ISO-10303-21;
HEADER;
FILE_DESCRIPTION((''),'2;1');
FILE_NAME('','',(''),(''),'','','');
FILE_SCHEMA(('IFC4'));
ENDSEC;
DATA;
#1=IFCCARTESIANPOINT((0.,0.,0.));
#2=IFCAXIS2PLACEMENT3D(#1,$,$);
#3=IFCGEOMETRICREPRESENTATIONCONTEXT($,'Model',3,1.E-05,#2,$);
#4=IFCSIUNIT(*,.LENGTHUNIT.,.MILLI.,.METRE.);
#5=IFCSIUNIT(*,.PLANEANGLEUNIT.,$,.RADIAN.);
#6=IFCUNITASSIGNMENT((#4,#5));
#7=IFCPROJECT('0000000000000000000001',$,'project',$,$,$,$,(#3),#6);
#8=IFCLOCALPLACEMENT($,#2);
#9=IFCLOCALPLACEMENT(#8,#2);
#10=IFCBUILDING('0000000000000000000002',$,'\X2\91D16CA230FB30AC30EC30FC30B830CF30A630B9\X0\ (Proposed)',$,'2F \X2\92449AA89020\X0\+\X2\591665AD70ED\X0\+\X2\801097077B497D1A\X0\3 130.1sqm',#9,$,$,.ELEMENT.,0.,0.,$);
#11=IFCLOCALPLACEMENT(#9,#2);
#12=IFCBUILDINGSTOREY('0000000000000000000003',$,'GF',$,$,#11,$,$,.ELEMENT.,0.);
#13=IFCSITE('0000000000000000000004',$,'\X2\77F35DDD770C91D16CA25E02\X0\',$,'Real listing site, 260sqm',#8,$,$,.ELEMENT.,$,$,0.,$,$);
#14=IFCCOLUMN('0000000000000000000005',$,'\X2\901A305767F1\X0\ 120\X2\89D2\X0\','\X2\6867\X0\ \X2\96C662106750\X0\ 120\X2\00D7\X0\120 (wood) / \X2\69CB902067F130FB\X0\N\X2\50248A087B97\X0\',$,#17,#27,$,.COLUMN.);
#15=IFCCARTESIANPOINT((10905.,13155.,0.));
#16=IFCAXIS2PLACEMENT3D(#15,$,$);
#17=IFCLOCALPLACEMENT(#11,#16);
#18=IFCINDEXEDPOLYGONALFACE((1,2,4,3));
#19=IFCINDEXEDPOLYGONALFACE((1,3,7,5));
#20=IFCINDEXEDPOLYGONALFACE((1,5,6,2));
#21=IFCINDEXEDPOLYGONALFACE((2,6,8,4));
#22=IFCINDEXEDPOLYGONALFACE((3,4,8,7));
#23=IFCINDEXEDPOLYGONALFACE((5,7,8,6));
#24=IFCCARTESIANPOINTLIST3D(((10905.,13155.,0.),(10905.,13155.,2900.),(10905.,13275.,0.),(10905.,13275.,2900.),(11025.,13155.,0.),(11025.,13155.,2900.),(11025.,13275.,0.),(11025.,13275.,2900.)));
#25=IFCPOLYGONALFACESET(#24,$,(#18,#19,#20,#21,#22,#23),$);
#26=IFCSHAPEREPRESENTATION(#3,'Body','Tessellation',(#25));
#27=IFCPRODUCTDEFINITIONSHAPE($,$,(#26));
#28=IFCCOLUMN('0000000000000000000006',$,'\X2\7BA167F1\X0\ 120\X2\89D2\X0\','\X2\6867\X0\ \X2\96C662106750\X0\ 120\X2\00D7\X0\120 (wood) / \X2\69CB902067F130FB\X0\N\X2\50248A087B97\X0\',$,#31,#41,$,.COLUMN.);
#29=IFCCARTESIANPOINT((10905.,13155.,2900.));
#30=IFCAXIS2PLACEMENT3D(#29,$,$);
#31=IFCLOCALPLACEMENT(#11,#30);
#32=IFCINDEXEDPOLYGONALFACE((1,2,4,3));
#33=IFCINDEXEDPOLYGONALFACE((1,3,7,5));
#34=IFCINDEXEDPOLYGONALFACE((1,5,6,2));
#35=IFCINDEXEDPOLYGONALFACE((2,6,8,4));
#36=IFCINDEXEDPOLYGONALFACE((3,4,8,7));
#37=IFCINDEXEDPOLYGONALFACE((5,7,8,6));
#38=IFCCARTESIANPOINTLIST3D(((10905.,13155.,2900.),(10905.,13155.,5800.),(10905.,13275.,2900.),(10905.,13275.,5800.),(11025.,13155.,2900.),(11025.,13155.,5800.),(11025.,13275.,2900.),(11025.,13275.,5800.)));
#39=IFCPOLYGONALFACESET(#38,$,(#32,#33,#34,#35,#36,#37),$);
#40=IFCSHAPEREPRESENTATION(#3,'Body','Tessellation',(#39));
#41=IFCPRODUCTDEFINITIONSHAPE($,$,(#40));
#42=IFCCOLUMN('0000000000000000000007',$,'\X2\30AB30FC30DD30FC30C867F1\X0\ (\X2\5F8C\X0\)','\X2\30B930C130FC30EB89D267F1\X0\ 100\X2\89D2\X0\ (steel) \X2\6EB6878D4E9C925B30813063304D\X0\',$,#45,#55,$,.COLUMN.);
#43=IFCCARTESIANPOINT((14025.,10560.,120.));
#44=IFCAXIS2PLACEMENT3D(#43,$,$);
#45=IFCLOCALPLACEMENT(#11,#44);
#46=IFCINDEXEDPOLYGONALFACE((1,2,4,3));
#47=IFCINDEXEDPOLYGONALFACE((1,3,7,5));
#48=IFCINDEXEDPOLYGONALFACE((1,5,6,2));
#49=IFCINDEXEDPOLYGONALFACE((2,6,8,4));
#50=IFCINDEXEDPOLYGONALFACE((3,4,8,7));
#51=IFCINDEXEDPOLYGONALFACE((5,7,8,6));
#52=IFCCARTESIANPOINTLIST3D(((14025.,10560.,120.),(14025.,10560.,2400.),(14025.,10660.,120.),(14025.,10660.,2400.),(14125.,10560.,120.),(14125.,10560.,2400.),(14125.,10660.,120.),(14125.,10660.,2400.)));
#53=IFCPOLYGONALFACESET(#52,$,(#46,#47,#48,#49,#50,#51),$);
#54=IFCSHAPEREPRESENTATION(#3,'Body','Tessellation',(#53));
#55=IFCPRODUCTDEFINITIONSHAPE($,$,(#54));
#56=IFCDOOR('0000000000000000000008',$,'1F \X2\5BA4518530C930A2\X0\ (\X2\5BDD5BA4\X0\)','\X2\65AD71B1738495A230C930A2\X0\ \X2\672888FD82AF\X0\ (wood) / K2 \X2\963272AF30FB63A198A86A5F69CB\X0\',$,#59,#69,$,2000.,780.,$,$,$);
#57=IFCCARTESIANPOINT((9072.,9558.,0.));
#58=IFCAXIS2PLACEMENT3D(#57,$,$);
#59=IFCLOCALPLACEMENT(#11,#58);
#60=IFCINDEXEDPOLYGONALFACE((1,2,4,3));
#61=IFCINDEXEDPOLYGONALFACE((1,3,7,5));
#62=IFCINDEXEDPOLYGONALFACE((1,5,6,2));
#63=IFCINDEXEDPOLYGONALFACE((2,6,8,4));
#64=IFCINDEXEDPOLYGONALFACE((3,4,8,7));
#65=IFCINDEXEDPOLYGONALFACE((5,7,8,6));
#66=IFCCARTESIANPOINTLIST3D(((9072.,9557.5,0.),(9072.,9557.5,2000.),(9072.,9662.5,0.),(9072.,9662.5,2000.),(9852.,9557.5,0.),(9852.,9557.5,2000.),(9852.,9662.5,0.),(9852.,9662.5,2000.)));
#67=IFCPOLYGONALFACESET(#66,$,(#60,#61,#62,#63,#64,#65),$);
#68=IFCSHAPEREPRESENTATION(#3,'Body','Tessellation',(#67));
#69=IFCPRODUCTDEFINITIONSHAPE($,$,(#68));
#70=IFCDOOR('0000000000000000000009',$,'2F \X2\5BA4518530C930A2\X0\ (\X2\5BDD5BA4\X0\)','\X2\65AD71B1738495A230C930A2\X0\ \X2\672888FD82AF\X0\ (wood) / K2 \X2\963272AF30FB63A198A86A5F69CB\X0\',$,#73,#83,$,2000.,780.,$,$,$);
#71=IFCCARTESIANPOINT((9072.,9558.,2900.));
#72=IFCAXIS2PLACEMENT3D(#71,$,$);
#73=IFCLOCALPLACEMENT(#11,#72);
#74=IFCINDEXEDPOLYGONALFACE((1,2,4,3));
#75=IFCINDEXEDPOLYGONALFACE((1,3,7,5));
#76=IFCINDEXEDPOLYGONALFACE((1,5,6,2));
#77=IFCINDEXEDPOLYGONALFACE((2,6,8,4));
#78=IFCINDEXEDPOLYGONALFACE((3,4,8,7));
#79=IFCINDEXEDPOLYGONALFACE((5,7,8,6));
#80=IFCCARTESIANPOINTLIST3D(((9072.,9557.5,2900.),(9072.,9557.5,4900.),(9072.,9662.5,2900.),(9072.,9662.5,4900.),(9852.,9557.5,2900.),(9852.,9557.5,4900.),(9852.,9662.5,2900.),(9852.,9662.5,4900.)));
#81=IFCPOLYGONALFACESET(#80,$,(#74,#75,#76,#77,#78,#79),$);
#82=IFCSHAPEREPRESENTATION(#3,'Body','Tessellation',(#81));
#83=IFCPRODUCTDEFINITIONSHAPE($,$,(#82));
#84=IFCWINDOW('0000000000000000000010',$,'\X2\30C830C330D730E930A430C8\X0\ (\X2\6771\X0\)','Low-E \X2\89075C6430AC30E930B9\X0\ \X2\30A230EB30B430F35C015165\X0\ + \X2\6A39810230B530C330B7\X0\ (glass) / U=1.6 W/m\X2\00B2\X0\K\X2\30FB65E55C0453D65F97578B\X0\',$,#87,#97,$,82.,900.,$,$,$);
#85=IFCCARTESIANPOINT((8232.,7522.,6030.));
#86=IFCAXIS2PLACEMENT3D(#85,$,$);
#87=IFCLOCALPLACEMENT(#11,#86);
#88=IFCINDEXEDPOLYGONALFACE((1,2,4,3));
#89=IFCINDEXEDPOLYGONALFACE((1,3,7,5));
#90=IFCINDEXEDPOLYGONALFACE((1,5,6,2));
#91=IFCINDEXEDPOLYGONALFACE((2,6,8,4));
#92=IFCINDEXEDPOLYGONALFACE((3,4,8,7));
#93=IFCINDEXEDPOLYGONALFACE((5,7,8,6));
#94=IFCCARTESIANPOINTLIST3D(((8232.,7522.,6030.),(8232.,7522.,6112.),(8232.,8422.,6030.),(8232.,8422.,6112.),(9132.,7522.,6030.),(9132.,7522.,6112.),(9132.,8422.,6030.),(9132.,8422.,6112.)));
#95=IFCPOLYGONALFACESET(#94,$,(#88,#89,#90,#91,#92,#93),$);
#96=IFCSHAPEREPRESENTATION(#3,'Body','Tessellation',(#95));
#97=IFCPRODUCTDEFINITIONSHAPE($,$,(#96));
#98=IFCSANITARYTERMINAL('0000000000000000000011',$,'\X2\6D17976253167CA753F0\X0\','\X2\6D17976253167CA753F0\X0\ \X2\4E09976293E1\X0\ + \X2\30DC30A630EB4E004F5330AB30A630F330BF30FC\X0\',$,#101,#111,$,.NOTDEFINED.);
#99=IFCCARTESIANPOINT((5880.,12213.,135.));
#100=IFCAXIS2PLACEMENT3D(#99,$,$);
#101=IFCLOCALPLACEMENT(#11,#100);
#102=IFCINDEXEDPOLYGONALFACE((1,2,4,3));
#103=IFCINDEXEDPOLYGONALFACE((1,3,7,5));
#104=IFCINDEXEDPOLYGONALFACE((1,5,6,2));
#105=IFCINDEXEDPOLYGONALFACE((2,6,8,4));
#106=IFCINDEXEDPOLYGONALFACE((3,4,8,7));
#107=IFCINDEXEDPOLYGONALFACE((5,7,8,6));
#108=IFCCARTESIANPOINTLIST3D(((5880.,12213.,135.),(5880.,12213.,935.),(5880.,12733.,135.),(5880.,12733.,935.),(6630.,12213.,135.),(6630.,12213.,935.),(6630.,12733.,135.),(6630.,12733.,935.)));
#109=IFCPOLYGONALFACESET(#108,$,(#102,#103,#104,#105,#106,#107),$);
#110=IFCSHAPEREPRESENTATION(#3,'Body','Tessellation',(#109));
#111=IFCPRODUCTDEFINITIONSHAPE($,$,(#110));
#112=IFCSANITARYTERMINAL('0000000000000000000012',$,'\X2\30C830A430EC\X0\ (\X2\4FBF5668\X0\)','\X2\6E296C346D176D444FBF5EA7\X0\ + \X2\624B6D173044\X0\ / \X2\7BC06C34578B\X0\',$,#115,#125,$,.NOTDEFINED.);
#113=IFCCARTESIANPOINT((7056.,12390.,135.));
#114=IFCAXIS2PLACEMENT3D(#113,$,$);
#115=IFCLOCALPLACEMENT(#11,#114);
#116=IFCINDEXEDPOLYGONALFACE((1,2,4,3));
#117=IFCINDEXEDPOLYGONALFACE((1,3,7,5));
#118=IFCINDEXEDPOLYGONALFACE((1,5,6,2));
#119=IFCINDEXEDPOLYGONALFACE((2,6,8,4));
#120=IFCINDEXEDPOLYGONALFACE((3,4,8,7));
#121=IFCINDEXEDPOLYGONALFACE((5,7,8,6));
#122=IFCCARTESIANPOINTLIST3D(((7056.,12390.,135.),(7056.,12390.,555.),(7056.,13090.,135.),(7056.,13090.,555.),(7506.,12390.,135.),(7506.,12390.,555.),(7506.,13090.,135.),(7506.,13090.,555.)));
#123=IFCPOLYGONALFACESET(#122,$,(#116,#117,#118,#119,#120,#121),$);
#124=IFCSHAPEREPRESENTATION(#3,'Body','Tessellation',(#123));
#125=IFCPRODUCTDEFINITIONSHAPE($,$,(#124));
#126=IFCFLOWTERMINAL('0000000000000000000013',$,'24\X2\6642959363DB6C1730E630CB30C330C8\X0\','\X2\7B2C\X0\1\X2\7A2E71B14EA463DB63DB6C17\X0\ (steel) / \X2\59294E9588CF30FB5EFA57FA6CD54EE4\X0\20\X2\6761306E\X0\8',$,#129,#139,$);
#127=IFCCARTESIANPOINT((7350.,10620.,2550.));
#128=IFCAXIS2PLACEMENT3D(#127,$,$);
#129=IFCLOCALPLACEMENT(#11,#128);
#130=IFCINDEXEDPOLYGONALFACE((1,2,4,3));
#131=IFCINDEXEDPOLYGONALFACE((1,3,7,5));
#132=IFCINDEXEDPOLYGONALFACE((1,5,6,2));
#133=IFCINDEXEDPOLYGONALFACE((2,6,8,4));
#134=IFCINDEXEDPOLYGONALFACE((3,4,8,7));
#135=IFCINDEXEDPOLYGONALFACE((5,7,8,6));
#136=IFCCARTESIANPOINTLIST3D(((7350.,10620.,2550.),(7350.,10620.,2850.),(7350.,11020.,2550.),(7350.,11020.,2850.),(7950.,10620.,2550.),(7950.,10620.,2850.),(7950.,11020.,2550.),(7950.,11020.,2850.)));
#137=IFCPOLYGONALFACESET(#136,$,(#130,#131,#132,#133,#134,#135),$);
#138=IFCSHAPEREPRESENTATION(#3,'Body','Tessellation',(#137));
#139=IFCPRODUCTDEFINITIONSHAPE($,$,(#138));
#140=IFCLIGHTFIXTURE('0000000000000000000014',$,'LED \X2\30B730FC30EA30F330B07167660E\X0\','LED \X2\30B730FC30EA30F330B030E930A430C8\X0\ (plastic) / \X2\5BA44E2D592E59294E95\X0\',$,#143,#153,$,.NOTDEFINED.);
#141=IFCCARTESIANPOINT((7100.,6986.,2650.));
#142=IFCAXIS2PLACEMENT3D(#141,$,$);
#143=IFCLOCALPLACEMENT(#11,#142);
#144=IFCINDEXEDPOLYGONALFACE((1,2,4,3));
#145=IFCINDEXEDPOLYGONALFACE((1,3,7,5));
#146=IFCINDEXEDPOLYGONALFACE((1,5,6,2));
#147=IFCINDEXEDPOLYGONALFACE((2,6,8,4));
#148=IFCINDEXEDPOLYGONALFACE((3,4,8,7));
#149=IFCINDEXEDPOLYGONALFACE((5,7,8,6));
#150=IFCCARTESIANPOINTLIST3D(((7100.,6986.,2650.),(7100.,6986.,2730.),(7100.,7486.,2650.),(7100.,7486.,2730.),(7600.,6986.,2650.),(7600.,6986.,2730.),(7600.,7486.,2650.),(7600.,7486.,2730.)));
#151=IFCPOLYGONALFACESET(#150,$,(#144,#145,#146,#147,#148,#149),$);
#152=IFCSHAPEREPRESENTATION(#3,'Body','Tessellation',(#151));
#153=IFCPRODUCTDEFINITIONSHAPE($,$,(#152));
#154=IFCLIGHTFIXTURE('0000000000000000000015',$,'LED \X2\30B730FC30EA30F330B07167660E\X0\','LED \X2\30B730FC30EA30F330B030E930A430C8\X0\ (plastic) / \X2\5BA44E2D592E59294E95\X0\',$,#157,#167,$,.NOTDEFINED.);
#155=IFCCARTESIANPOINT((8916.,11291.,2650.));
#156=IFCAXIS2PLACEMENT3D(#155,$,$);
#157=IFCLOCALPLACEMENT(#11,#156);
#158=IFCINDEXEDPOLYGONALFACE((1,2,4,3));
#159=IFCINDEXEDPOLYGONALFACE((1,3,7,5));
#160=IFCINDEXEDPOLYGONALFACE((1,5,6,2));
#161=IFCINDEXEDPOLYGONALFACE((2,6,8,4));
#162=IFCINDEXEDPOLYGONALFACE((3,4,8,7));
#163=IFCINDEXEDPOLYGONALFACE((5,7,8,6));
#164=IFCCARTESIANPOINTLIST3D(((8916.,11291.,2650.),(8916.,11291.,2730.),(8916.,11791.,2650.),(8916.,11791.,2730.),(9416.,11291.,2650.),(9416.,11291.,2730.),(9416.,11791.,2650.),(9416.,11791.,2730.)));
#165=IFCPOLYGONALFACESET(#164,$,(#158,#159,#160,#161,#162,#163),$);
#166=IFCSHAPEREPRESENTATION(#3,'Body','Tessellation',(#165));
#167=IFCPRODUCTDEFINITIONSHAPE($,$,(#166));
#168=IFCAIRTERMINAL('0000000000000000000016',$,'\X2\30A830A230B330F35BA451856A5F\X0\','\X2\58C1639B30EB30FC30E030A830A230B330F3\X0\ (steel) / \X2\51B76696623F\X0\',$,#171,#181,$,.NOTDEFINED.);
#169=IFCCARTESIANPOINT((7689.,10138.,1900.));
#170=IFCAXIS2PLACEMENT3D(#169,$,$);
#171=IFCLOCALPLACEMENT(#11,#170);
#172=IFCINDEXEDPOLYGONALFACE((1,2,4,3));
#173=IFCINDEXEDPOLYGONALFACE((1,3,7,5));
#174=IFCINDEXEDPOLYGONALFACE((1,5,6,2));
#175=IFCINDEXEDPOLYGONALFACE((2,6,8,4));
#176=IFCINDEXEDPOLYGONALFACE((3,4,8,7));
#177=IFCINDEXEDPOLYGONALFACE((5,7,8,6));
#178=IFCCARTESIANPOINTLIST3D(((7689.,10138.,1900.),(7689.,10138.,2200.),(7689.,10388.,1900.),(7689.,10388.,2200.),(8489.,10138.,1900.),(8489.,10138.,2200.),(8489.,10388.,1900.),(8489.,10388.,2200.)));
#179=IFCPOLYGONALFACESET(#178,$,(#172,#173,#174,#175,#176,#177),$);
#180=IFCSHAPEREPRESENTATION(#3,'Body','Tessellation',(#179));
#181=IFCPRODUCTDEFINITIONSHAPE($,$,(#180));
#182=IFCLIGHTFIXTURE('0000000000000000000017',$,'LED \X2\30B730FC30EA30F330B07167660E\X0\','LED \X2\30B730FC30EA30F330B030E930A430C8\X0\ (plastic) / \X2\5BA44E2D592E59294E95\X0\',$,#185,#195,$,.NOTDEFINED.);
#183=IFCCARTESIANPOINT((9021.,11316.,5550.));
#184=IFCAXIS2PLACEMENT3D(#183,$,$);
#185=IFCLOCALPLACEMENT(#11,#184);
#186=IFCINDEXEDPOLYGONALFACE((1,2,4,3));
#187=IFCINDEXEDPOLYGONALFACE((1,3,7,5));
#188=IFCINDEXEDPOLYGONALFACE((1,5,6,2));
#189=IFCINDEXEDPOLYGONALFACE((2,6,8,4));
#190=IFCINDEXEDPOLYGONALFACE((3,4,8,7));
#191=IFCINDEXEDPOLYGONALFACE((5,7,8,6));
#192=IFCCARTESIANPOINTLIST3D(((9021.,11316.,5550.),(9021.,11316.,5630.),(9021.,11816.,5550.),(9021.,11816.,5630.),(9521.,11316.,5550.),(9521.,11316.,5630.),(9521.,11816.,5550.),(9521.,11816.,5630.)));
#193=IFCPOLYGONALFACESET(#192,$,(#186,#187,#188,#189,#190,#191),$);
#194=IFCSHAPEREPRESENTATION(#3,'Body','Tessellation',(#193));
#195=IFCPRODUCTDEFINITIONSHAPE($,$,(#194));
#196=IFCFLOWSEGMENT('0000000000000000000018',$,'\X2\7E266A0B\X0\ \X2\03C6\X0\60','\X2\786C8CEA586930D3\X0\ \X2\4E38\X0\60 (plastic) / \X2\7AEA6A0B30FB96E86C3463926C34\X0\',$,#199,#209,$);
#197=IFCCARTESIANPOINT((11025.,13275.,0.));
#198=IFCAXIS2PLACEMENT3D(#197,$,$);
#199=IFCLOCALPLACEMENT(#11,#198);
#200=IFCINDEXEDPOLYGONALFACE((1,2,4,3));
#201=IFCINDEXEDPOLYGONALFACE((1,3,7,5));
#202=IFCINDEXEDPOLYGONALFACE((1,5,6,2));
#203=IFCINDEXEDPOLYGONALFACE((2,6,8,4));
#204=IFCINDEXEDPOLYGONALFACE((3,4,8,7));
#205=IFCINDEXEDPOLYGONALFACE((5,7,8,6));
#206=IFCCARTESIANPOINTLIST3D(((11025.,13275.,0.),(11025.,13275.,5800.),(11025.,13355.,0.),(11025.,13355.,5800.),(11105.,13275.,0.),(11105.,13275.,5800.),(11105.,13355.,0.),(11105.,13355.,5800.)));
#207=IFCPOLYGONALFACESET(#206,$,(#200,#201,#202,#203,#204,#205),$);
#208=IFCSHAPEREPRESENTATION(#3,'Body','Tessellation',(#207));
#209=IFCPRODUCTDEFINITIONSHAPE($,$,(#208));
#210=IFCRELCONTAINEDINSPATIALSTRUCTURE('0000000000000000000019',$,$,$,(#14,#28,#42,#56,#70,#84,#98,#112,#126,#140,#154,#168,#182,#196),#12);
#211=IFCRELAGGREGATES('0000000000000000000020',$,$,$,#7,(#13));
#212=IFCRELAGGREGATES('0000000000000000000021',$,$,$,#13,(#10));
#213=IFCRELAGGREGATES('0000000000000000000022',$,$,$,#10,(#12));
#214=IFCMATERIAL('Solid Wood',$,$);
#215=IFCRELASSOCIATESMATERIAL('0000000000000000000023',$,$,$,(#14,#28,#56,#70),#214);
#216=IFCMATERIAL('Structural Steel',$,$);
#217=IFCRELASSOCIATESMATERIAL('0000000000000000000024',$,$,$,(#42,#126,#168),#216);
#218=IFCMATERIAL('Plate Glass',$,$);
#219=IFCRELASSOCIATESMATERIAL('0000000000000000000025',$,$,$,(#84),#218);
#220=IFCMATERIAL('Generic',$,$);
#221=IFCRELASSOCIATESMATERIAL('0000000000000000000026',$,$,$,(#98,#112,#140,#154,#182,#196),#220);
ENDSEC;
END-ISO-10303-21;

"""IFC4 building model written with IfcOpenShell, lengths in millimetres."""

from ifc_helpers import new_model, si_unit, frame, frame_2d, origin, place, context, project, spatial, rectangle, extrude, material, element, save


model = new_model("IFC4")

# Units and contexts
model_context = context("Model", 3, precision=1e-05, world=origin())
ifc_project = project(units=[si_unit("LENGTHUNIT", "METRE", prefix="MILLI"), si_unit("PLANEANGLEUNIT", "RADIAN")], contexts=[model_context])

# Site, building, storey
site_placement = place(None, origin())
site = spatial("IfcSite", under=ifc_project, at=site_placement, Name="石川県金沢市", ObjectType="Real listing site, 260sqm", CompositionType="ELEMENT", RefElevation=0.0)
building_placement = place(site_placement, origin())
building = spatial("IfcBuilding", under=site, at=building_placement, Name="金沢・ガレージハウス (Proposed)", ObjectType="2F 鉄骨造+外断热+耐震等級3 130.1sqm", CompositionType="ELEMENT", ElevationOfRefHeight=0.0, ElevationOfTerrain=0.0)
storey_placement = place(building_placement, origin())
storey = spatial("IfcBuildingStorey", under=building, at=storey_placement, Name="GF", CompositionType="ELEMENT", Elevation=0.0)

# Columns
ifc_material_1 = material(Name="Solid Wood")
column_1_placement = place(storey_placement, frame((10905.0, 13155.0, 0.0)))
element("IfcColumn", 1, at=column_1_placement, inside=storey, material=ifc_material_1, Name="通し柱 120角", Description="桧 集成材 120×120 (wood) / 構造柱・N値計算", PredefinedType="COLUMN", context=model_context, shape_type="SweptSolid", body=[
    extrude(rectangle(XDim=120.0, YDim=120.0, at=frame_2d((60.0, 60.0))), frame((10905.0, 13155.0, 0.0)), (0.0, 0.0, 1.0), 2900.0),
])
column_2_placement = place(storey_placement, frame((10905.0, 13155.0, 2900.0)))
element("IfcColumn", 2, at=column_2_placement, inside=storey, material=ifc_material_1, Name="管柱 120角", Description="桧 集成材 120×120 (wood) / 構造柱・N値計算", PredefinedType="COLUMN", context=model_context, shape_type="SweptSolid", body=[
    extrude(rectangle(XDim=120.0, YDim=120.0, at=frame_2d((60.0, 60.0))), frame((10905.0, 13155.0, 2900.0)), (0.0, 0.0, 1.0), 2900.0),
])
ifc_material_2 = material(Name="Structural Steel")
column_3_placement = place(storey_placement, frame((14025.0, 10560.0, 120.0)))
element("IfcColumn", 3, at=column_3_placement, inside=storey, material=ifc_material_2, Name="カーポート柱 (後)", Description="スチール角柱 100角 (steel) 溶融亜鉛めっき", PredefinedType="COLUMN", context=model_context, shape_type="SweptSolid", body=[
    extrude(rectangle(XDim=100.0, YDim=100.0, at=frame_2d((50.0, 50.0))), frame((14025.0, 10560.0, 120.0)), (0.0, 0.0, 1.0), 2280.0),
])

# Door
door_1_placement = place(storey_placement, frame((9072.0, 9558.0, 0.0)))
element("IfcDoor", 4, at=door_1_placement, inside=storey, material=ifc_material_1, Name="1F 室内ドア (寝室)", Description="断熱玄関ドア 木製芯 (wood) / K2 防犯・採風機構", OverallHeight=2000.0, OverallWidth=780.0, context=model_context, shape_type="SweptSolid", body=[
    extrude(rectangle(XDim=780.0, YDim=105.0, at=frame_2d((390.0, 52.0))), frame((9072.0, 9558.0, 0.0)), (0.0, 0.0, 1.0), 2000.0),
])

# Door
door_2_placement = place(storey_placement, frame((9072.0, 9558.0, 2900.0)))
element("IfcDoor", 5, at=door_2_placement, inside=storey, material=ifc_material_1, Name="2F 室内ドア (寝室)", Description="断熱玄関ドア 木製芯 (wood) / K2 防犯・採風機構", OverallHeight=2000.0, OverallWidth=780.0, context=model_context, shape_type="SweptSolid", body=[
    extrude(rectangle(XDim=780.0, YDim=105.0, at=frame_2d((390.0, 52.0))), frame((9072.0, 9558.0, 2900.0)), (0.0, 0.0, 1.0), 2000.0),
])

# Window
ifc_material_3 = material(Name="Plate Glass")
window_placement = place(storey_placement, frame((8232.0, 7522.0, 6030.0)))
element("IfcWindow", 6, at=window_placement, inside=storey, material=ifc_material_3, Name="トップライト (東)", Description="Low-E 複層ガラス アルゴン封入 + 樹脂サッシ (glass) / U=1.6 W/m²K・日射取得型", OverallHeight=82.0, OverallWidth=900.0, context=model_context, shape_type="SweptSolid", body=[
    extrude(rectangle(XDim=900.0, YDim=900.0, at=frame_2d((450.0, 450.0))), frame((8232.0, 7522.0, 6030.0)), (0.0, 0.0, 1.0), 82.0),
])

# Sanitary terminals
ifc_material_4 = material(Name="Generic")
sanitary_terminal_1_placement = place(storey_placement, frame((5880.0, 12213.0, 135.0)))
element("IfcSanitaryTerminal", 7, at=sanitary_terminal_1_placement, inside=storey, material=ifc_material_4, Name="洗面化粧台", Description="洗面化粧台 三面鏡 + ボウル一体カウンター", PredefinedType="NOTDEFINED", context=model_context, shape_type="SweptSolid", body=[
    extrude(rectangle(XDim=750.0, YDim=520.0, at=frame_2d((375.0, 260.0))), frame((5880.0, 12213.0, 135.0)), (0.0, 0.0, 1.0), 800.0),
])
sanitary_terminal_2_placement = place(storey_placement, frame((7056.0, 12390.0, 135.0)))
element("IfcSanitaryTerminal", 8, at=sanitary_terminal_2_placement, inside=storey, material=ifc_material_4, Name="トイレ (便器)", Description="温水洗浄便座 + 手洗い / 節水型", PredefinedType="NOTDEFINED", context=model_context, shape_type="SweptSolid", body=[
    extrude(rectangle(XDim=450.0, YDim=700.0, at=frame_2d((225.0, 350.0))), frame((7056.0, 12390.0, 135.0)), (0.0, 0.0, 1.0), 420.0),
])

# Flow terminal
flow_terminal_placement = place(storey_placement, frame((7350.0, 10620.0, 2550.0)))
element("IfcFlowTerminal", 9, at=flow_terminal_placement, inside=storey, material=ifc_material_2, Name="24時間換気ユニット", Description="第1種熱交換換気 (steel) / 天井裏・建基法令20条の8", context=model_context, shape_type="SweptSolid", body=[
    extrude(rectangle(XDim=600.0, YDim=400.0, at=frame_2d((300.0, 200.0))), frame((7350.0, 10620.0, 2550.0)), (0.0, 0.0, 1.0), 300.0),
])

# Light fixtures
light_fixture_1_placement = place(storey_placement, frame((7100.0, 6986.0, 2650.0)))
element("IfcLightFixture", 10, at=light_fixture_1_placement, inside=storey, material=ifc_material_4, Name="LED シーリング照明", Description="LED シーリングライト (plastic) / 室中央天井", PredefinedType="NOTDEFINED", context=model_context, shape_type="SweptSolid", body=[
    extrude(rectangle(XDim=500.0, YDim=500.0, at=frame_2d((250.0, 250.0))), frame((7100.0, 6986.0, 2650.0)), (0.0, 0.0, 1.0), 80.0),
])
light_fixture_2_placement = place(storey_placement, frame((8916.0, 11291.0, 2650.0)))
element("IfcLightFixture", 11, at=light_fixture_2_placement, inside=storey, material=ifc_material_4, Name="LED シーリング照明", Description="LED シーリングライト (plastic) / 室中央天井", PredefinedType="NOTDEFINED", context=model_context, shape_type="SweptSolid", body=[
    extrude(rectangle(XDim=500.0, YDim=500.0, at=frame_2d((250.0, 250.0))), frame((8916.0, 11291.0, 2650.0)), (0.0, 0.0, 1.0), 80.0),
])

# Air terminal
air_terminal_placement = place(storey_placement, frame((7689.0, 10138.0, 1900.0)))
element("IfcAirTerminal", 12, at=air_terminal_placement, inside=storey, material=ifc_material_2, Name="エアコン室内機", Description="壁掛ルームエアコン (steel) / 冷暖房", PredefinedType="NOTDEFINED", context=model_context, shape_type="SweptSolid", body=[
    extrude(rectangle(XDim=800.0, YDim=250.0, at=frame_2d((400.0, 125.0))), frame((7689.0, 10138.0, 1900.0)), (0.0, 0.0, 1.0), 300.0),
])

# Light fixture
light_fixture_3_placement = place(storey_placement, frame((9021.0, 11316.0, 5550.0)))
element("IfcLightFixture", 13, at=light_fixture_3_placement, inside=storey, material=ifc_material_4, Name="LED シーリング照明", Description="LED シーリングライト (plastic) / 室中央天井", PredefinedType="NOTDEFINED", context=model_context, shape_type="SweptSolid", body=[
    extrude(rectangle(XDim=500.0, YDim=500.0, at=frame_2d((250.0, 250.0))), frame((9021.0, 11316.0, 5550.0)), (0.0, 0.0, 1.0), 80.0),
])

# Flow segment
flow_segment_placement = place(storey_placement, frame((11025.0, 13275.0, 0.0)))
element("IfcFlowSegment", 14, at=flow_segment_placement, inside=storey, material=ifc_material_4, Name="縦樋 φ60", Description="硬質塩ビ 丸60 (plastic) / 竪樋・雨水排水", context=model_context, shape_type="SweptSolid", body=[
    extrude(rectangle(XDim=80.0, YDim=80.0, at=frame_2d((40.0, 40.0))), frame((11025.0, 13275.0, 0.0)), (0.0, 0.0, 1.0), 5800.0),
])

save(model, "model.ifc")
